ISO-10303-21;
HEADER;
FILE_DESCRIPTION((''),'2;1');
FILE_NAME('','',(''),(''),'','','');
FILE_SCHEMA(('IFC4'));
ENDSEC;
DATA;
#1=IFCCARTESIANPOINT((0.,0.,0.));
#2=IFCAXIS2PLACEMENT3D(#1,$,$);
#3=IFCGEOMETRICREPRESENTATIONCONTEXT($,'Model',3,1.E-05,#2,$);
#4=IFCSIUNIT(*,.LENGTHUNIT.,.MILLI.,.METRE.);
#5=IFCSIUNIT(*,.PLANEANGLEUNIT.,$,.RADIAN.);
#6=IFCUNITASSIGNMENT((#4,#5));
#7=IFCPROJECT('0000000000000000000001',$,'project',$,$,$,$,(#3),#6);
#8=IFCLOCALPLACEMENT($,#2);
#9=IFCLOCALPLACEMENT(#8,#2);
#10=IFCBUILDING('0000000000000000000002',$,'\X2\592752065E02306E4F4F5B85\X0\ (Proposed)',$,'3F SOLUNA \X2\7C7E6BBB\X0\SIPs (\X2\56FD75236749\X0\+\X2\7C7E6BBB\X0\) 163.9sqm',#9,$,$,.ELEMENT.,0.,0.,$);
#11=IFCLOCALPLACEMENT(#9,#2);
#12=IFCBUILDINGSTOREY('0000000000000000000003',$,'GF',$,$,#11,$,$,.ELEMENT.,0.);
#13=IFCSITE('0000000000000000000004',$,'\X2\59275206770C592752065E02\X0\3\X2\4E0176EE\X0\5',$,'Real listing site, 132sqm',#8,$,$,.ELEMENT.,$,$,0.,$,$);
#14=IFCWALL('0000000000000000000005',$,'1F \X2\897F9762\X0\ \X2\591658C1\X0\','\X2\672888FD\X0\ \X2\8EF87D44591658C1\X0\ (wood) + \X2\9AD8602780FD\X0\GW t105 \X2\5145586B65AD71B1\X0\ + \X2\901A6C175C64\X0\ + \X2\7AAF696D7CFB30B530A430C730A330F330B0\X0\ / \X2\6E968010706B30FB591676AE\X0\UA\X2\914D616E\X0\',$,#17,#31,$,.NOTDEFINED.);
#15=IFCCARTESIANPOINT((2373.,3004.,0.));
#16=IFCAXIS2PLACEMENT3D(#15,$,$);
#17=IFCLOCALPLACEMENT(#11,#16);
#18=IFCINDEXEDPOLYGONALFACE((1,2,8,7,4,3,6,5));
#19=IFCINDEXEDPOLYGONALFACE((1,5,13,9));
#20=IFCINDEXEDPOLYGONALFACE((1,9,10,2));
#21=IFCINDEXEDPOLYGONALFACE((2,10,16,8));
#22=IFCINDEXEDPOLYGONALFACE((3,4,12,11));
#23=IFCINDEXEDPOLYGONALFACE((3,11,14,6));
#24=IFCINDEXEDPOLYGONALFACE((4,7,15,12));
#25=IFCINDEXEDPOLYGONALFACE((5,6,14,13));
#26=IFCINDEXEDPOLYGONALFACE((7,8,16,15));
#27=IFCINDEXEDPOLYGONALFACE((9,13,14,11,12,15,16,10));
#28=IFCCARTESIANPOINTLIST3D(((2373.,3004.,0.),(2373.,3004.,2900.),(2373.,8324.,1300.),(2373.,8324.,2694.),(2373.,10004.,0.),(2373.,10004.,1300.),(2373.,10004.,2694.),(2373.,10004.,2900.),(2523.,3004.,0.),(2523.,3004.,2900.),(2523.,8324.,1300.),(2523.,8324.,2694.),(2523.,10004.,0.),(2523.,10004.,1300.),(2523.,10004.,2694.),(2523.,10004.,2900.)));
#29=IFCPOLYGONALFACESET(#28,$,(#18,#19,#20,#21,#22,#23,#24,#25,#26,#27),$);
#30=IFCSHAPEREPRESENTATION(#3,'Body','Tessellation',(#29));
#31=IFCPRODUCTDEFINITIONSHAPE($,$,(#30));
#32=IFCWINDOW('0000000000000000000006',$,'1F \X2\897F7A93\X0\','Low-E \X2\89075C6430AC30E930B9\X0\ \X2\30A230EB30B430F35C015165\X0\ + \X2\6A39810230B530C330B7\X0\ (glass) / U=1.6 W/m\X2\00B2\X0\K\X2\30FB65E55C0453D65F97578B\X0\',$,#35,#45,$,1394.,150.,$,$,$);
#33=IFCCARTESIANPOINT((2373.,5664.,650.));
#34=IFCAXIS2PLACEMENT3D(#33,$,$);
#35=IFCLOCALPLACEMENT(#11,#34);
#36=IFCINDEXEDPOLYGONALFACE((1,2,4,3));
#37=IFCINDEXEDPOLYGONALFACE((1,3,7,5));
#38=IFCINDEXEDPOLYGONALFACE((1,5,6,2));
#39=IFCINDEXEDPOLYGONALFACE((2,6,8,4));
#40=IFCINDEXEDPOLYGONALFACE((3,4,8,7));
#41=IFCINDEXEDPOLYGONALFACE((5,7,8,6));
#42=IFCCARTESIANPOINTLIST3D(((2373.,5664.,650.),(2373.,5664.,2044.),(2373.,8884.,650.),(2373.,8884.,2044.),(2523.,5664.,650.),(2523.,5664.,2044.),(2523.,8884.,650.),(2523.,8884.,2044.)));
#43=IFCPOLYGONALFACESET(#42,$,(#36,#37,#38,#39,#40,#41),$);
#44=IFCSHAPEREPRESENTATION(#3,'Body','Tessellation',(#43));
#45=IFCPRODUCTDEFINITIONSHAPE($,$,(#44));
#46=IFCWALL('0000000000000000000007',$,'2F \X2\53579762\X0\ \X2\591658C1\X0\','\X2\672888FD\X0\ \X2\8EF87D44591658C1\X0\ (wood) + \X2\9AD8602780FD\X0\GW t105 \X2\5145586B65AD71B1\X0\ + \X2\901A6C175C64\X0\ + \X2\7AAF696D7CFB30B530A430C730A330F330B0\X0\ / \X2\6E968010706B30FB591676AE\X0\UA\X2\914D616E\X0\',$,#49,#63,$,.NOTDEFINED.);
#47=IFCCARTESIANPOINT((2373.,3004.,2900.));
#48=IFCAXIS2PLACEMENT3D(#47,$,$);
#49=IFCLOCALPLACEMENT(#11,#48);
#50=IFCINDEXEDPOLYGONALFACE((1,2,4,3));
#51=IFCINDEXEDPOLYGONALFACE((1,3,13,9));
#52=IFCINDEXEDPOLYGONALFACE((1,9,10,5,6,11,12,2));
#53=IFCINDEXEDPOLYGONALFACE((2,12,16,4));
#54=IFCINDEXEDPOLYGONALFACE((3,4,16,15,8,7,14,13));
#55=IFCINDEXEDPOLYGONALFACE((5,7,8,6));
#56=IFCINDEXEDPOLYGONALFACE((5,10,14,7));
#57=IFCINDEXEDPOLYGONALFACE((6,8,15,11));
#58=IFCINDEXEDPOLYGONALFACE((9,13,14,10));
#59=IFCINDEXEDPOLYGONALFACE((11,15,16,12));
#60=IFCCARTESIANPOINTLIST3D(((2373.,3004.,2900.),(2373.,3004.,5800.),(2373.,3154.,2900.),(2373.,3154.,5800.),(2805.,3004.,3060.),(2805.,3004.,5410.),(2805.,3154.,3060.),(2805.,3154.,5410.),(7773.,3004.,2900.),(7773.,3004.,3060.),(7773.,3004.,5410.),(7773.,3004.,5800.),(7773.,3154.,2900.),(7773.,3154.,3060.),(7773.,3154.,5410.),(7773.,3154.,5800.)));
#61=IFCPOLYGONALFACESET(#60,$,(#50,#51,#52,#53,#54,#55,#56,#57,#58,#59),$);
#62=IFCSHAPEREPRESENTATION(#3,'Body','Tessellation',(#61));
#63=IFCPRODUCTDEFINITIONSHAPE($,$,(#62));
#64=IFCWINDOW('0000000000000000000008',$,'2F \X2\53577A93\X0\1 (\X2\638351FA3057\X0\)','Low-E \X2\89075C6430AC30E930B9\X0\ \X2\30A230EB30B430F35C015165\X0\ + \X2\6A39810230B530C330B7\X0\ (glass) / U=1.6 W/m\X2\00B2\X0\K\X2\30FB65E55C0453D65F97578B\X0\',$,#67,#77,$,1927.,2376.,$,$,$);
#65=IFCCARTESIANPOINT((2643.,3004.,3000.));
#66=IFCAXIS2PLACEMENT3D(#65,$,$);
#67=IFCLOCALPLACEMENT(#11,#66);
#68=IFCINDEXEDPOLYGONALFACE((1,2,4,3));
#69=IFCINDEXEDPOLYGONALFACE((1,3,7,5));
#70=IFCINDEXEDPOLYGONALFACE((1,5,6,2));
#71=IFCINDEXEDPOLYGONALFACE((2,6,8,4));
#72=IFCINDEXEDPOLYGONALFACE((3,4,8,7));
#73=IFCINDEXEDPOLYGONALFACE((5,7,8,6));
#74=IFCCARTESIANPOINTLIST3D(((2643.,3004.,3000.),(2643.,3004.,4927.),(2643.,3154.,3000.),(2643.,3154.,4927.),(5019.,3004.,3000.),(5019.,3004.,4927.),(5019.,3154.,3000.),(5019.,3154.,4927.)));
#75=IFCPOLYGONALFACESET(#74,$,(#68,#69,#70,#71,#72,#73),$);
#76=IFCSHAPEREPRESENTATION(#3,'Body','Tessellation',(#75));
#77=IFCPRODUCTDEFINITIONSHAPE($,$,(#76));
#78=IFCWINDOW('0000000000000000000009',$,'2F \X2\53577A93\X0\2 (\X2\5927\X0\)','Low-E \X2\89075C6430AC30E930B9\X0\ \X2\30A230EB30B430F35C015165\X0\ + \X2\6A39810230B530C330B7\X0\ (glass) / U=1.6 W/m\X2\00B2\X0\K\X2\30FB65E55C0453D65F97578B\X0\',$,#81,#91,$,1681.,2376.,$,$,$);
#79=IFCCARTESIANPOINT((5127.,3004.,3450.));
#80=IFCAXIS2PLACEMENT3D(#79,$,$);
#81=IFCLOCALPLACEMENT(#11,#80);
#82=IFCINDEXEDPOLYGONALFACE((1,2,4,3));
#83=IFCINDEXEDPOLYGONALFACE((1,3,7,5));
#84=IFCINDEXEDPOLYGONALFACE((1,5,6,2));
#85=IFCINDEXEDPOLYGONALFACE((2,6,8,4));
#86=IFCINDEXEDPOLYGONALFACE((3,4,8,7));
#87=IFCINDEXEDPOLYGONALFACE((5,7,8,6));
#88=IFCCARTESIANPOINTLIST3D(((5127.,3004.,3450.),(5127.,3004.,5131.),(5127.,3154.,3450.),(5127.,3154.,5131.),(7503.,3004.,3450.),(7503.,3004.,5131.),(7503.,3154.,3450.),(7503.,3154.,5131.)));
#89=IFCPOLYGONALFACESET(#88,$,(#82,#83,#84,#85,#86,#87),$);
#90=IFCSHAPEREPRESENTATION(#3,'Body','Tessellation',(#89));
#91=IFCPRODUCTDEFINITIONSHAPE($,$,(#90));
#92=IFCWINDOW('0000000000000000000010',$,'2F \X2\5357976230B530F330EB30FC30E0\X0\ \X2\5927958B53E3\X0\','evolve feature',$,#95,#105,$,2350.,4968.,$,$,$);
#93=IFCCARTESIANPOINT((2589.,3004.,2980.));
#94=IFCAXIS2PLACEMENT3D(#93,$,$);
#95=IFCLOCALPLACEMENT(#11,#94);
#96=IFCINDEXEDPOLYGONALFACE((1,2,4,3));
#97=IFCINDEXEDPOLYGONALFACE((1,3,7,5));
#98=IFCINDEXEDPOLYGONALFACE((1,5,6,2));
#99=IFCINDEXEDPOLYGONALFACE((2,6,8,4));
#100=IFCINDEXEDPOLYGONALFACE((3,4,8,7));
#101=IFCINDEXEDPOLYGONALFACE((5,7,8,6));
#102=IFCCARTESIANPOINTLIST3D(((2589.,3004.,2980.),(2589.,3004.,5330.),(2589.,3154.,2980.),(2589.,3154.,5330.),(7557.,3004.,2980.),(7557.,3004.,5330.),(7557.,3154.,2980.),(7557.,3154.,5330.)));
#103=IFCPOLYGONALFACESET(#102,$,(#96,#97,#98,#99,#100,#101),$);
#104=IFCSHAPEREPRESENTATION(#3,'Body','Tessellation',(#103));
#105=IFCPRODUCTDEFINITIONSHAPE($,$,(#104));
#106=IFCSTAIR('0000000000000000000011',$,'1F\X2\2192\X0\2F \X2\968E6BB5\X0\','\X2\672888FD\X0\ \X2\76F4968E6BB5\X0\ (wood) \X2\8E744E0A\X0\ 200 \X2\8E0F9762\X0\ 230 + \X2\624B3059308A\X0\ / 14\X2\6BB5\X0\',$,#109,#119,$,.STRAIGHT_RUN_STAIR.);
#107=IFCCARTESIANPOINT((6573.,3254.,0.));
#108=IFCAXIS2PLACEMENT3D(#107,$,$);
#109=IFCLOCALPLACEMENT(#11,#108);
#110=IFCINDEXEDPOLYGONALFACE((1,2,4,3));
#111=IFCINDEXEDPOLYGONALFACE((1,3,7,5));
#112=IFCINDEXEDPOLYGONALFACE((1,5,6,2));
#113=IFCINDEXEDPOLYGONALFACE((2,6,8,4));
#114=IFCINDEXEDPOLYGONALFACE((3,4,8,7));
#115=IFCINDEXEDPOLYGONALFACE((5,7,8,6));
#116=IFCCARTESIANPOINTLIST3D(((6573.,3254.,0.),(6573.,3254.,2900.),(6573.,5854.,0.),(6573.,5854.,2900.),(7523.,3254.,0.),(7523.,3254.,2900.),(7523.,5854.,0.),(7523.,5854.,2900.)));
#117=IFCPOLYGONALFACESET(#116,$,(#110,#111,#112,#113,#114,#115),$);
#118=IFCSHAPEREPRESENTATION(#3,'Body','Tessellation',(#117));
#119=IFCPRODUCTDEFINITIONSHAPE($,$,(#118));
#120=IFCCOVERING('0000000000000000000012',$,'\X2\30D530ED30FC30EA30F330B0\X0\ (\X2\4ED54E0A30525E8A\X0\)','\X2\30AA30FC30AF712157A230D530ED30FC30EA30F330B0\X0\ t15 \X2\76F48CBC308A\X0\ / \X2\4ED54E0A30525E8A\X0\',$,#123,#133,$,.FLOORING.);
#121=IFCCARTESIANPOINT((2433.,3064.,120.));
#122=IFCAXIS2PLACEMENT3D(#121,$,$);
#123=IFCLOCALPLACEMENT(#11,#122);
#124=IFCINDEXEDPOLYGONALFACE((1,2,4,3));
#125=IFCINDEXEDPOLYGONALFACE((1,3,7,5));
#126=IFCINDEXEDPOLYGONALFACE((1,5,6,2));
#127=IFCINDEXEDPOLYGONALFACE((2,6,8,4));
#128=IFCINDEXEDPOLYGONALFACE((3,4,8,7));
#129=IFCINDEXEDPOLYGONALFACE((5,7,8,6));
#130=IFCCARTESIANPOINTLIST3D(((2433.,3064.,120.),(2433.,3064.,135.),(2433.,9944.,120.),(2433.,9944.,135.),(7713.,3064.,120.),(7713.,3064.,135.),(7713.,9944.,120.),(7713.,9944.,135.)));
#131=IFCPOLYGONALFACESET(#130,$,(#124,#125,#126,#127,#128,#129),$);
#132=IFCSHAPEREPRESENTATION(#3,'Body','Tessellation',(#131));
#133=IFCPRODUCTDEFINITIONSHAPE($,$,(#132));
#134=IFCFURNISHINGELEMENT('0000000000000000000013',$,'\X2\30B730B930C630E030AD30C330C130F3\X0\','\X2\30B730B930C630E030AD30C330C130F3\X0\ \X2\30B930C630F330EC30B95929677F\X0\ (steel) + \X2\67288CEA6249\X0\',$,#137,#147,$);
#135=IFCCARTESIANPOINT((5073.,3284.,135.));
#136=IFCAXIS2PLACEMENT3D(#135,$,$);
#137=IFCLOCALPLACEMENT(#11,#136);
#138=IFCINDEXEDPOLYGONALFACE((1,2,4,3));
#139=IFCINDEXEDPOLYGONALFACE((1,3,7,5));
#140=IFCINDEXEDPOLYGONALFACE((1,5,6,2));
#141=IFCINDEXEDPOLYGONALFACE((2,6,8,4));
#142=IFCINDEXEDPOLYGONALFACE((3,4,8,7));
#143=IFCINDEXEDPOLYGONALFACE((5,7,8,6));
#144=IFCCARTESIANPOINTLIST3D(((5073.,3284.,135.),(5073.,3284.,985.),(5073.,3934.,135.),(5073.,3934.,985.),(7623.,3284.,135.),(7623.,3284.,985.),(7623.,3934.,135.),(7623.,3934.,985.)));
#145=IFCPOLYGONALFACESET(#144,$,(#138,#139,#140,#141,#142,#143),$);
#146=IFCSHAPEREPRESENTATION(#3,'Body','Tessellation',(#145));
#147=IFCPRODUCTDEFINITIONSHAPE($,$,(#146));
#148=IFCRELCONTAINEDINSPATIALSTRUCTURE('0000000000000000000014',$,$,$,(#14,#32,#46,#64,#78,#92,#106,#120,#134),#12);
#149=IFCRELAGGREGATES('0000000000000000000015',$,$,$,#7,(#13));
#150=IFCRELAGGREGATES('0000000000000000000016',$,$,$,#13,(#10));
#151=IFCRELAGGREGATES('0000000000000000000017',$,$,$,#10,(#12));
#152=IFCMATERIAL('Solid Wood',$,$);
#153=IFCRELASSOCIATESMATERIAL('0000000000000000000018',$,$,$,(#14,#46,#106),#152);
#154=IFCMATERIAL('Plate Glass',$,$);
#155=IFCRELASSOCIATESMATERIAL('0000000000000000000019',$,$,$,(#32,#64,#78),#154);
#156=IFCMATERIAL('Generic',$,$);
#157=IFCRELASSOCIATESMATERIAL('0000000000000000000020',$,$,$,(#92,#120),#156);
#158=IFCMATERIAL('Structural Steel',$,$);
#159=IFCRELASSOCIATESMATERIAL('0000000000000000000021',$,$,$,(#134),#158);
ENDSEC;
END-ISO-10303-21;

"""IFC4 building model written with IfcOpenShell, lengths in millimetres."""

from ifc_helpers import new_model, si_unit, frame, frame_2d, origin, place, context, project, spatial, rectangle, extrude, material, element, fill, save


model = new_model("IFC4")

# Units and contexts
model_context = context("Model", 3, precision=1e-05, world=origin())
ifc_project = project(units=[si_unit("LENGTHUNIT", "METRE", prefix="MILLI"), si_unit("PLANEANGLEUNIT", "RADIAN")], contexts=[model_context])

# Site, building, storey
site_placement = place(None, origin())
site = spatial("IfcSite", under=ifc_project, at=site_placement, Name="大分県大分市3丁目5", ObjectType="Real listing site, 132sqm", CompositionType="ELEMENT", RefElevation=0.0)
building_placement = place(site_placement, origin())
building = spatial("IfcBuilding", under=site, at=building_placement, Name="大分市の住宅 (Proposed)", ObjectType="3F SOLUNA 籾殻SIPs (国産杉+籾殻) 163.9sqm", CompositionType="ELEMENT", ElevationOfRefHeight=0.0, ElevationOfTerrain=0.0)
storey_placement = place(building_placement, origin())
storey = spatial("IfcBuildingStorey", under=building, at=storey_placement, Name="GF", CompositionType="ELEMENT", Elevation=0.0)

# Shared definitions
ifc_material_1 = material(Name="Solid Wood")
ifc_material_2 = material(Name="Generic")

# Shared definitions
ifc_material_3 = material(Name="Plate Glass")

# Wall, opening, window
wall_1_placement = place(storey_placement, frame((2373.0, 3004.0, 0.0)))
wall_1 = element("IfcWall", 1, at=wall_1_placement, inside=storey, material=ifc_material_1, Name="1F 西面 外壁", Description="木製 軸組外壁 (wood) + 高性能GW t105 充填断熱 + 通気層 + 窯業系サイディング / 準耐火・外皮UA配慮", PredefinedType="NOTDEFINED", context=model_context, shape_type="SweptSolid", body=[
    extrude(rectangle(XDim=150.0, YDim=7000.0, at=frame_2d((75.0, 3500.0))), frame((2373.0, 3004.0, 0.0)), (0.0, 0.0, 1.0), 2900.0),
])
opening_1_placement = place(storey_placement, frame((2373.0, 5664.0, 650.0)))
opening_1 = element("IfcOpeningElement", 2, at=opening_1_placement, cuts=wall_1, PredefinedType="NOTDEFINED", context=model_context, shape_type="SweptSolid", body=[
    extrude(rectangle(XDim=150.0, YDim=3220.0, at=frame_2d((75.0, 1610.0))), frame((2373.0, 5664.0, 650.0)), (0.0, 0.0, 1.0), 1394.0),
])
window_1_placement = place(storey_placement, frame((2373.0, 5664.0, 650.0)))
window_1 = element("IfcWindow", 3, at=window_1_placement, inside=storey, material=ifc_material_3, Name="1F 西窓", Description="Low-E 複層ガラス アルゴン封入 + 樹脂サッシ (glass) / U=1.6 W/m²K・日射取得型", OverallHeight=1394.0, OverallWidth=150.0, context=model_context, shape_type="SweptSolid", body=[
    extrude(rectangle(XDim=150.0, YDim=3220.0, at=frame_2d((75.0, 1610.0))), frame((2373.0, 5664.0, 650.0)), (0.0, 0.0, 1.0), 1394.0),
])
fill(opening_1, window_1)

# Wall, openings, windows
wall_2_placement = place(storey_placement, frame((2373.0, 3004.0, 2900.0)))
wall_2 = element("IfcWall", 4, at=wall_2_placement, inside=storey, material=ifc_material_1, Name="2F 南面 外壁", Description="木製 軸組外壁 (wood) + 高性能GW t105 充填断熱 + 通気層 + 窯業系サイディング / 準耐火・外皮UA配慮", PredefinedType="NOTDEFINED", context=model_context, shape_type="SweptSolid", body=[
    extrude(rectangle(XDim=5400.0, YDim=150.0, at=frame_2d((2700.0, 75.0))), frame((2373.0, 3004.0, 2900.0)), (0.0, 0.0, 1.0), 2900.0),
])
opening_2_placement = place(storey_placement, frame((2643.0, 3004.0, 3000.0)))
opening_2 = element("IfcOpeningElement", 5, at=opening_2_placement, cuts=wall_2, PredefinedType="NOTDEFINED", context=model_context, shape_type="SweptSolid", body=[
    extrude(rectangle(XDim=2376.0, YDim=150.0, at=frame_2d((1188.0, 75.0))), frame((2643.0, 3004.0, 3000.0)), (0.0, 0.0, 1.0), 1927.0),
])
opening_3_placement = place(storey_placement, frame((5127.0, 3004.0, 3450.0)))
opening_3 = element("IfcOpeningElement", 6, at=opening_3_placement, cuts=wall_2, PredefinedType="NOTDEFINED", context=model_context, shape_type="SweptSolid", body=[
    extrude(rectangle(XDim=2376.0, YDim=150.0, at=frame_2d((1188.0, 75.0))), frame((5127.0, 3004.0, 3450.0)), (0.0, 0.0, 1.0), 1681.0),
])
opening_4_placement = place(storey_placement, frame((2589.0, 3004.0, 2980.0)))
opening_4 = element("IfcOpeningElement", 7, at=opening_4_placement, cuts=wall_2, PredefinedType="NOTDEFINED", context=model_context, shape_type="SweptSolid", body=[
    extrude(rectangle(XDim=4968.0, YDim=150.0, at=frame_2d((2484.0, 75.0))), frame((2589.0, 3004.0, 2980.0)), (0.0, 0.0, 1.0), 2350.0),
])
window_2_placement = place(storey_placement, frame((2643.0, 3004.0, 3000.0)))
window_2 = element("IfcWindow", 8, at=window_2_placement, inside=storey, material=ifc_material_3, Name="2F 南窓1 (掃出し)", Description="Low-E 複層ガラス アルゴン封入 + 樹脂サッシ (glass) / U=1.6 W/m²K・日射取得型", OverallHeight=1927.0, OverallWidth=2376.0, context=model_context, shape_type="SweptSolid", body=[
    extrude(rectangle(XDim=2376.0, YDim=150.0, at=frame_2d((1188.0, 75.0))), frame((2643.0, 3004.0, 3000.0)), (0.0, 0.0, 1.0), 1927.0),
])
fill(opening_2, window_2)
window_3_placement = place(storey_placement, frame((5127.0, 3004.0, 3450.0)))
window_3 = element("IfcWindow", 9, at=window_3_placement, inside=storey, material=ifc_material_3, Name="2F 南窓2 (大)", Description="Low-E 複層ガラス アルゴン封入 + 樹脂サッシ (glass) / U=1.6 W/m²K・日射取得型", OverallHeight=1681.0, OverallWidth=2376.0, context=model_context, shape_type="SweptSolid", body=[
    extrude(rectangle(XDim=2376.0, YDim=150.0, at=frame_2d((1188.0, 75.0))), frame((5127.0, 3004.0, 3450.0)), (0.0, 0.0, 1.0), 1681.0),
])
fill(opening_3, window_3)
window_4_placement = place(storey_placement, frame((2589.0, 3004.0, 2980.0)))
window_4 = element("IfcWindow", 10, at=window_4_placement, inside=storey, material=ifc_material_2, Name="2F 南面サンルーム 大開口", Description="evolve feature", OverallHeight=2350.0, OverallWidth=4968.0, context=model_context, shape_type="SweptSolid", body=[
    extrude(rectangle(XDim=4968.0, YDim=150.0, at=frame_2d((2484.0, 75.0))), frame((2589.0, 3004.0, 2980.0)), (0.0, 0.0, 1.0), 2350.0),
])
fill(opening_4, window_4)

# Stair
stair_placement = place(storey_placement, frame((6573.0, 3254.0, 0.0)))
element("IfcStair", 11, at=stair_placement, inside=storey, material=ifc_material_1, Name="1F→2F 階段", Description="木製 直階段 (wood) 蹴上 200 踏面 230 + 手すり / 14段", PredefinedType="STRAIGHT_RUN_STAIR", context=model_context, shape_type="SweptSolid", body=[
    extrude(rectangle(XDim=950.0, YDim=2600.0, at=frame_2d((475.0, 1300.0))), frame((6573.0, 3254.0, 0.0)), (0.0, 0.0, 1.0), 2900.0),
])

# Covering
covering_placement = place(storey_placement, frame((2433.0, 3064.0, 120.0)))
element("IfcCovering", 12, at=covering_placement, inside=storey, material=ifc_material_2, Name="フローリング (仕上げ床)", Description="オーク無垢フローリング t15 直貼り / 仕上げ床", PredefinedType="FLOORING", context=model_context, shape_type="SweptSolid", body=[
    extrude(rectangle(XDim=5280.0, YDim=6880.0, at=frame_2d((2640.0, 3440.0))), frame((2433.0, 3064.0, 120.0)), (0.0, 0.0, 1.0), 15.0),
])

# Furnishing element
ifc_material_4 = material(Name="Structural Steel")
furnishing_placement = place(storey_placement, frame((5073.0, 3284.0, 135.0)))
element("IfcFurnishingElement", 13, at=furnishing_placement, inside=storey, material=ifc_material_4, Name="システムキッチン", Description="システムキッチン ステンレス天板 (steel) + 木質扉", context=model_context, shape_type="SweptSolid", body=[
    extrude(rectangle(XDim=2550.0, YDim=650.0, at=frame_2d((1275.0, 325.0))), frame((5073.0, 3284.0, 135.0)), (0.0, 0.0, 1.0), 850.0),
])

save(model, "model.ifc")
